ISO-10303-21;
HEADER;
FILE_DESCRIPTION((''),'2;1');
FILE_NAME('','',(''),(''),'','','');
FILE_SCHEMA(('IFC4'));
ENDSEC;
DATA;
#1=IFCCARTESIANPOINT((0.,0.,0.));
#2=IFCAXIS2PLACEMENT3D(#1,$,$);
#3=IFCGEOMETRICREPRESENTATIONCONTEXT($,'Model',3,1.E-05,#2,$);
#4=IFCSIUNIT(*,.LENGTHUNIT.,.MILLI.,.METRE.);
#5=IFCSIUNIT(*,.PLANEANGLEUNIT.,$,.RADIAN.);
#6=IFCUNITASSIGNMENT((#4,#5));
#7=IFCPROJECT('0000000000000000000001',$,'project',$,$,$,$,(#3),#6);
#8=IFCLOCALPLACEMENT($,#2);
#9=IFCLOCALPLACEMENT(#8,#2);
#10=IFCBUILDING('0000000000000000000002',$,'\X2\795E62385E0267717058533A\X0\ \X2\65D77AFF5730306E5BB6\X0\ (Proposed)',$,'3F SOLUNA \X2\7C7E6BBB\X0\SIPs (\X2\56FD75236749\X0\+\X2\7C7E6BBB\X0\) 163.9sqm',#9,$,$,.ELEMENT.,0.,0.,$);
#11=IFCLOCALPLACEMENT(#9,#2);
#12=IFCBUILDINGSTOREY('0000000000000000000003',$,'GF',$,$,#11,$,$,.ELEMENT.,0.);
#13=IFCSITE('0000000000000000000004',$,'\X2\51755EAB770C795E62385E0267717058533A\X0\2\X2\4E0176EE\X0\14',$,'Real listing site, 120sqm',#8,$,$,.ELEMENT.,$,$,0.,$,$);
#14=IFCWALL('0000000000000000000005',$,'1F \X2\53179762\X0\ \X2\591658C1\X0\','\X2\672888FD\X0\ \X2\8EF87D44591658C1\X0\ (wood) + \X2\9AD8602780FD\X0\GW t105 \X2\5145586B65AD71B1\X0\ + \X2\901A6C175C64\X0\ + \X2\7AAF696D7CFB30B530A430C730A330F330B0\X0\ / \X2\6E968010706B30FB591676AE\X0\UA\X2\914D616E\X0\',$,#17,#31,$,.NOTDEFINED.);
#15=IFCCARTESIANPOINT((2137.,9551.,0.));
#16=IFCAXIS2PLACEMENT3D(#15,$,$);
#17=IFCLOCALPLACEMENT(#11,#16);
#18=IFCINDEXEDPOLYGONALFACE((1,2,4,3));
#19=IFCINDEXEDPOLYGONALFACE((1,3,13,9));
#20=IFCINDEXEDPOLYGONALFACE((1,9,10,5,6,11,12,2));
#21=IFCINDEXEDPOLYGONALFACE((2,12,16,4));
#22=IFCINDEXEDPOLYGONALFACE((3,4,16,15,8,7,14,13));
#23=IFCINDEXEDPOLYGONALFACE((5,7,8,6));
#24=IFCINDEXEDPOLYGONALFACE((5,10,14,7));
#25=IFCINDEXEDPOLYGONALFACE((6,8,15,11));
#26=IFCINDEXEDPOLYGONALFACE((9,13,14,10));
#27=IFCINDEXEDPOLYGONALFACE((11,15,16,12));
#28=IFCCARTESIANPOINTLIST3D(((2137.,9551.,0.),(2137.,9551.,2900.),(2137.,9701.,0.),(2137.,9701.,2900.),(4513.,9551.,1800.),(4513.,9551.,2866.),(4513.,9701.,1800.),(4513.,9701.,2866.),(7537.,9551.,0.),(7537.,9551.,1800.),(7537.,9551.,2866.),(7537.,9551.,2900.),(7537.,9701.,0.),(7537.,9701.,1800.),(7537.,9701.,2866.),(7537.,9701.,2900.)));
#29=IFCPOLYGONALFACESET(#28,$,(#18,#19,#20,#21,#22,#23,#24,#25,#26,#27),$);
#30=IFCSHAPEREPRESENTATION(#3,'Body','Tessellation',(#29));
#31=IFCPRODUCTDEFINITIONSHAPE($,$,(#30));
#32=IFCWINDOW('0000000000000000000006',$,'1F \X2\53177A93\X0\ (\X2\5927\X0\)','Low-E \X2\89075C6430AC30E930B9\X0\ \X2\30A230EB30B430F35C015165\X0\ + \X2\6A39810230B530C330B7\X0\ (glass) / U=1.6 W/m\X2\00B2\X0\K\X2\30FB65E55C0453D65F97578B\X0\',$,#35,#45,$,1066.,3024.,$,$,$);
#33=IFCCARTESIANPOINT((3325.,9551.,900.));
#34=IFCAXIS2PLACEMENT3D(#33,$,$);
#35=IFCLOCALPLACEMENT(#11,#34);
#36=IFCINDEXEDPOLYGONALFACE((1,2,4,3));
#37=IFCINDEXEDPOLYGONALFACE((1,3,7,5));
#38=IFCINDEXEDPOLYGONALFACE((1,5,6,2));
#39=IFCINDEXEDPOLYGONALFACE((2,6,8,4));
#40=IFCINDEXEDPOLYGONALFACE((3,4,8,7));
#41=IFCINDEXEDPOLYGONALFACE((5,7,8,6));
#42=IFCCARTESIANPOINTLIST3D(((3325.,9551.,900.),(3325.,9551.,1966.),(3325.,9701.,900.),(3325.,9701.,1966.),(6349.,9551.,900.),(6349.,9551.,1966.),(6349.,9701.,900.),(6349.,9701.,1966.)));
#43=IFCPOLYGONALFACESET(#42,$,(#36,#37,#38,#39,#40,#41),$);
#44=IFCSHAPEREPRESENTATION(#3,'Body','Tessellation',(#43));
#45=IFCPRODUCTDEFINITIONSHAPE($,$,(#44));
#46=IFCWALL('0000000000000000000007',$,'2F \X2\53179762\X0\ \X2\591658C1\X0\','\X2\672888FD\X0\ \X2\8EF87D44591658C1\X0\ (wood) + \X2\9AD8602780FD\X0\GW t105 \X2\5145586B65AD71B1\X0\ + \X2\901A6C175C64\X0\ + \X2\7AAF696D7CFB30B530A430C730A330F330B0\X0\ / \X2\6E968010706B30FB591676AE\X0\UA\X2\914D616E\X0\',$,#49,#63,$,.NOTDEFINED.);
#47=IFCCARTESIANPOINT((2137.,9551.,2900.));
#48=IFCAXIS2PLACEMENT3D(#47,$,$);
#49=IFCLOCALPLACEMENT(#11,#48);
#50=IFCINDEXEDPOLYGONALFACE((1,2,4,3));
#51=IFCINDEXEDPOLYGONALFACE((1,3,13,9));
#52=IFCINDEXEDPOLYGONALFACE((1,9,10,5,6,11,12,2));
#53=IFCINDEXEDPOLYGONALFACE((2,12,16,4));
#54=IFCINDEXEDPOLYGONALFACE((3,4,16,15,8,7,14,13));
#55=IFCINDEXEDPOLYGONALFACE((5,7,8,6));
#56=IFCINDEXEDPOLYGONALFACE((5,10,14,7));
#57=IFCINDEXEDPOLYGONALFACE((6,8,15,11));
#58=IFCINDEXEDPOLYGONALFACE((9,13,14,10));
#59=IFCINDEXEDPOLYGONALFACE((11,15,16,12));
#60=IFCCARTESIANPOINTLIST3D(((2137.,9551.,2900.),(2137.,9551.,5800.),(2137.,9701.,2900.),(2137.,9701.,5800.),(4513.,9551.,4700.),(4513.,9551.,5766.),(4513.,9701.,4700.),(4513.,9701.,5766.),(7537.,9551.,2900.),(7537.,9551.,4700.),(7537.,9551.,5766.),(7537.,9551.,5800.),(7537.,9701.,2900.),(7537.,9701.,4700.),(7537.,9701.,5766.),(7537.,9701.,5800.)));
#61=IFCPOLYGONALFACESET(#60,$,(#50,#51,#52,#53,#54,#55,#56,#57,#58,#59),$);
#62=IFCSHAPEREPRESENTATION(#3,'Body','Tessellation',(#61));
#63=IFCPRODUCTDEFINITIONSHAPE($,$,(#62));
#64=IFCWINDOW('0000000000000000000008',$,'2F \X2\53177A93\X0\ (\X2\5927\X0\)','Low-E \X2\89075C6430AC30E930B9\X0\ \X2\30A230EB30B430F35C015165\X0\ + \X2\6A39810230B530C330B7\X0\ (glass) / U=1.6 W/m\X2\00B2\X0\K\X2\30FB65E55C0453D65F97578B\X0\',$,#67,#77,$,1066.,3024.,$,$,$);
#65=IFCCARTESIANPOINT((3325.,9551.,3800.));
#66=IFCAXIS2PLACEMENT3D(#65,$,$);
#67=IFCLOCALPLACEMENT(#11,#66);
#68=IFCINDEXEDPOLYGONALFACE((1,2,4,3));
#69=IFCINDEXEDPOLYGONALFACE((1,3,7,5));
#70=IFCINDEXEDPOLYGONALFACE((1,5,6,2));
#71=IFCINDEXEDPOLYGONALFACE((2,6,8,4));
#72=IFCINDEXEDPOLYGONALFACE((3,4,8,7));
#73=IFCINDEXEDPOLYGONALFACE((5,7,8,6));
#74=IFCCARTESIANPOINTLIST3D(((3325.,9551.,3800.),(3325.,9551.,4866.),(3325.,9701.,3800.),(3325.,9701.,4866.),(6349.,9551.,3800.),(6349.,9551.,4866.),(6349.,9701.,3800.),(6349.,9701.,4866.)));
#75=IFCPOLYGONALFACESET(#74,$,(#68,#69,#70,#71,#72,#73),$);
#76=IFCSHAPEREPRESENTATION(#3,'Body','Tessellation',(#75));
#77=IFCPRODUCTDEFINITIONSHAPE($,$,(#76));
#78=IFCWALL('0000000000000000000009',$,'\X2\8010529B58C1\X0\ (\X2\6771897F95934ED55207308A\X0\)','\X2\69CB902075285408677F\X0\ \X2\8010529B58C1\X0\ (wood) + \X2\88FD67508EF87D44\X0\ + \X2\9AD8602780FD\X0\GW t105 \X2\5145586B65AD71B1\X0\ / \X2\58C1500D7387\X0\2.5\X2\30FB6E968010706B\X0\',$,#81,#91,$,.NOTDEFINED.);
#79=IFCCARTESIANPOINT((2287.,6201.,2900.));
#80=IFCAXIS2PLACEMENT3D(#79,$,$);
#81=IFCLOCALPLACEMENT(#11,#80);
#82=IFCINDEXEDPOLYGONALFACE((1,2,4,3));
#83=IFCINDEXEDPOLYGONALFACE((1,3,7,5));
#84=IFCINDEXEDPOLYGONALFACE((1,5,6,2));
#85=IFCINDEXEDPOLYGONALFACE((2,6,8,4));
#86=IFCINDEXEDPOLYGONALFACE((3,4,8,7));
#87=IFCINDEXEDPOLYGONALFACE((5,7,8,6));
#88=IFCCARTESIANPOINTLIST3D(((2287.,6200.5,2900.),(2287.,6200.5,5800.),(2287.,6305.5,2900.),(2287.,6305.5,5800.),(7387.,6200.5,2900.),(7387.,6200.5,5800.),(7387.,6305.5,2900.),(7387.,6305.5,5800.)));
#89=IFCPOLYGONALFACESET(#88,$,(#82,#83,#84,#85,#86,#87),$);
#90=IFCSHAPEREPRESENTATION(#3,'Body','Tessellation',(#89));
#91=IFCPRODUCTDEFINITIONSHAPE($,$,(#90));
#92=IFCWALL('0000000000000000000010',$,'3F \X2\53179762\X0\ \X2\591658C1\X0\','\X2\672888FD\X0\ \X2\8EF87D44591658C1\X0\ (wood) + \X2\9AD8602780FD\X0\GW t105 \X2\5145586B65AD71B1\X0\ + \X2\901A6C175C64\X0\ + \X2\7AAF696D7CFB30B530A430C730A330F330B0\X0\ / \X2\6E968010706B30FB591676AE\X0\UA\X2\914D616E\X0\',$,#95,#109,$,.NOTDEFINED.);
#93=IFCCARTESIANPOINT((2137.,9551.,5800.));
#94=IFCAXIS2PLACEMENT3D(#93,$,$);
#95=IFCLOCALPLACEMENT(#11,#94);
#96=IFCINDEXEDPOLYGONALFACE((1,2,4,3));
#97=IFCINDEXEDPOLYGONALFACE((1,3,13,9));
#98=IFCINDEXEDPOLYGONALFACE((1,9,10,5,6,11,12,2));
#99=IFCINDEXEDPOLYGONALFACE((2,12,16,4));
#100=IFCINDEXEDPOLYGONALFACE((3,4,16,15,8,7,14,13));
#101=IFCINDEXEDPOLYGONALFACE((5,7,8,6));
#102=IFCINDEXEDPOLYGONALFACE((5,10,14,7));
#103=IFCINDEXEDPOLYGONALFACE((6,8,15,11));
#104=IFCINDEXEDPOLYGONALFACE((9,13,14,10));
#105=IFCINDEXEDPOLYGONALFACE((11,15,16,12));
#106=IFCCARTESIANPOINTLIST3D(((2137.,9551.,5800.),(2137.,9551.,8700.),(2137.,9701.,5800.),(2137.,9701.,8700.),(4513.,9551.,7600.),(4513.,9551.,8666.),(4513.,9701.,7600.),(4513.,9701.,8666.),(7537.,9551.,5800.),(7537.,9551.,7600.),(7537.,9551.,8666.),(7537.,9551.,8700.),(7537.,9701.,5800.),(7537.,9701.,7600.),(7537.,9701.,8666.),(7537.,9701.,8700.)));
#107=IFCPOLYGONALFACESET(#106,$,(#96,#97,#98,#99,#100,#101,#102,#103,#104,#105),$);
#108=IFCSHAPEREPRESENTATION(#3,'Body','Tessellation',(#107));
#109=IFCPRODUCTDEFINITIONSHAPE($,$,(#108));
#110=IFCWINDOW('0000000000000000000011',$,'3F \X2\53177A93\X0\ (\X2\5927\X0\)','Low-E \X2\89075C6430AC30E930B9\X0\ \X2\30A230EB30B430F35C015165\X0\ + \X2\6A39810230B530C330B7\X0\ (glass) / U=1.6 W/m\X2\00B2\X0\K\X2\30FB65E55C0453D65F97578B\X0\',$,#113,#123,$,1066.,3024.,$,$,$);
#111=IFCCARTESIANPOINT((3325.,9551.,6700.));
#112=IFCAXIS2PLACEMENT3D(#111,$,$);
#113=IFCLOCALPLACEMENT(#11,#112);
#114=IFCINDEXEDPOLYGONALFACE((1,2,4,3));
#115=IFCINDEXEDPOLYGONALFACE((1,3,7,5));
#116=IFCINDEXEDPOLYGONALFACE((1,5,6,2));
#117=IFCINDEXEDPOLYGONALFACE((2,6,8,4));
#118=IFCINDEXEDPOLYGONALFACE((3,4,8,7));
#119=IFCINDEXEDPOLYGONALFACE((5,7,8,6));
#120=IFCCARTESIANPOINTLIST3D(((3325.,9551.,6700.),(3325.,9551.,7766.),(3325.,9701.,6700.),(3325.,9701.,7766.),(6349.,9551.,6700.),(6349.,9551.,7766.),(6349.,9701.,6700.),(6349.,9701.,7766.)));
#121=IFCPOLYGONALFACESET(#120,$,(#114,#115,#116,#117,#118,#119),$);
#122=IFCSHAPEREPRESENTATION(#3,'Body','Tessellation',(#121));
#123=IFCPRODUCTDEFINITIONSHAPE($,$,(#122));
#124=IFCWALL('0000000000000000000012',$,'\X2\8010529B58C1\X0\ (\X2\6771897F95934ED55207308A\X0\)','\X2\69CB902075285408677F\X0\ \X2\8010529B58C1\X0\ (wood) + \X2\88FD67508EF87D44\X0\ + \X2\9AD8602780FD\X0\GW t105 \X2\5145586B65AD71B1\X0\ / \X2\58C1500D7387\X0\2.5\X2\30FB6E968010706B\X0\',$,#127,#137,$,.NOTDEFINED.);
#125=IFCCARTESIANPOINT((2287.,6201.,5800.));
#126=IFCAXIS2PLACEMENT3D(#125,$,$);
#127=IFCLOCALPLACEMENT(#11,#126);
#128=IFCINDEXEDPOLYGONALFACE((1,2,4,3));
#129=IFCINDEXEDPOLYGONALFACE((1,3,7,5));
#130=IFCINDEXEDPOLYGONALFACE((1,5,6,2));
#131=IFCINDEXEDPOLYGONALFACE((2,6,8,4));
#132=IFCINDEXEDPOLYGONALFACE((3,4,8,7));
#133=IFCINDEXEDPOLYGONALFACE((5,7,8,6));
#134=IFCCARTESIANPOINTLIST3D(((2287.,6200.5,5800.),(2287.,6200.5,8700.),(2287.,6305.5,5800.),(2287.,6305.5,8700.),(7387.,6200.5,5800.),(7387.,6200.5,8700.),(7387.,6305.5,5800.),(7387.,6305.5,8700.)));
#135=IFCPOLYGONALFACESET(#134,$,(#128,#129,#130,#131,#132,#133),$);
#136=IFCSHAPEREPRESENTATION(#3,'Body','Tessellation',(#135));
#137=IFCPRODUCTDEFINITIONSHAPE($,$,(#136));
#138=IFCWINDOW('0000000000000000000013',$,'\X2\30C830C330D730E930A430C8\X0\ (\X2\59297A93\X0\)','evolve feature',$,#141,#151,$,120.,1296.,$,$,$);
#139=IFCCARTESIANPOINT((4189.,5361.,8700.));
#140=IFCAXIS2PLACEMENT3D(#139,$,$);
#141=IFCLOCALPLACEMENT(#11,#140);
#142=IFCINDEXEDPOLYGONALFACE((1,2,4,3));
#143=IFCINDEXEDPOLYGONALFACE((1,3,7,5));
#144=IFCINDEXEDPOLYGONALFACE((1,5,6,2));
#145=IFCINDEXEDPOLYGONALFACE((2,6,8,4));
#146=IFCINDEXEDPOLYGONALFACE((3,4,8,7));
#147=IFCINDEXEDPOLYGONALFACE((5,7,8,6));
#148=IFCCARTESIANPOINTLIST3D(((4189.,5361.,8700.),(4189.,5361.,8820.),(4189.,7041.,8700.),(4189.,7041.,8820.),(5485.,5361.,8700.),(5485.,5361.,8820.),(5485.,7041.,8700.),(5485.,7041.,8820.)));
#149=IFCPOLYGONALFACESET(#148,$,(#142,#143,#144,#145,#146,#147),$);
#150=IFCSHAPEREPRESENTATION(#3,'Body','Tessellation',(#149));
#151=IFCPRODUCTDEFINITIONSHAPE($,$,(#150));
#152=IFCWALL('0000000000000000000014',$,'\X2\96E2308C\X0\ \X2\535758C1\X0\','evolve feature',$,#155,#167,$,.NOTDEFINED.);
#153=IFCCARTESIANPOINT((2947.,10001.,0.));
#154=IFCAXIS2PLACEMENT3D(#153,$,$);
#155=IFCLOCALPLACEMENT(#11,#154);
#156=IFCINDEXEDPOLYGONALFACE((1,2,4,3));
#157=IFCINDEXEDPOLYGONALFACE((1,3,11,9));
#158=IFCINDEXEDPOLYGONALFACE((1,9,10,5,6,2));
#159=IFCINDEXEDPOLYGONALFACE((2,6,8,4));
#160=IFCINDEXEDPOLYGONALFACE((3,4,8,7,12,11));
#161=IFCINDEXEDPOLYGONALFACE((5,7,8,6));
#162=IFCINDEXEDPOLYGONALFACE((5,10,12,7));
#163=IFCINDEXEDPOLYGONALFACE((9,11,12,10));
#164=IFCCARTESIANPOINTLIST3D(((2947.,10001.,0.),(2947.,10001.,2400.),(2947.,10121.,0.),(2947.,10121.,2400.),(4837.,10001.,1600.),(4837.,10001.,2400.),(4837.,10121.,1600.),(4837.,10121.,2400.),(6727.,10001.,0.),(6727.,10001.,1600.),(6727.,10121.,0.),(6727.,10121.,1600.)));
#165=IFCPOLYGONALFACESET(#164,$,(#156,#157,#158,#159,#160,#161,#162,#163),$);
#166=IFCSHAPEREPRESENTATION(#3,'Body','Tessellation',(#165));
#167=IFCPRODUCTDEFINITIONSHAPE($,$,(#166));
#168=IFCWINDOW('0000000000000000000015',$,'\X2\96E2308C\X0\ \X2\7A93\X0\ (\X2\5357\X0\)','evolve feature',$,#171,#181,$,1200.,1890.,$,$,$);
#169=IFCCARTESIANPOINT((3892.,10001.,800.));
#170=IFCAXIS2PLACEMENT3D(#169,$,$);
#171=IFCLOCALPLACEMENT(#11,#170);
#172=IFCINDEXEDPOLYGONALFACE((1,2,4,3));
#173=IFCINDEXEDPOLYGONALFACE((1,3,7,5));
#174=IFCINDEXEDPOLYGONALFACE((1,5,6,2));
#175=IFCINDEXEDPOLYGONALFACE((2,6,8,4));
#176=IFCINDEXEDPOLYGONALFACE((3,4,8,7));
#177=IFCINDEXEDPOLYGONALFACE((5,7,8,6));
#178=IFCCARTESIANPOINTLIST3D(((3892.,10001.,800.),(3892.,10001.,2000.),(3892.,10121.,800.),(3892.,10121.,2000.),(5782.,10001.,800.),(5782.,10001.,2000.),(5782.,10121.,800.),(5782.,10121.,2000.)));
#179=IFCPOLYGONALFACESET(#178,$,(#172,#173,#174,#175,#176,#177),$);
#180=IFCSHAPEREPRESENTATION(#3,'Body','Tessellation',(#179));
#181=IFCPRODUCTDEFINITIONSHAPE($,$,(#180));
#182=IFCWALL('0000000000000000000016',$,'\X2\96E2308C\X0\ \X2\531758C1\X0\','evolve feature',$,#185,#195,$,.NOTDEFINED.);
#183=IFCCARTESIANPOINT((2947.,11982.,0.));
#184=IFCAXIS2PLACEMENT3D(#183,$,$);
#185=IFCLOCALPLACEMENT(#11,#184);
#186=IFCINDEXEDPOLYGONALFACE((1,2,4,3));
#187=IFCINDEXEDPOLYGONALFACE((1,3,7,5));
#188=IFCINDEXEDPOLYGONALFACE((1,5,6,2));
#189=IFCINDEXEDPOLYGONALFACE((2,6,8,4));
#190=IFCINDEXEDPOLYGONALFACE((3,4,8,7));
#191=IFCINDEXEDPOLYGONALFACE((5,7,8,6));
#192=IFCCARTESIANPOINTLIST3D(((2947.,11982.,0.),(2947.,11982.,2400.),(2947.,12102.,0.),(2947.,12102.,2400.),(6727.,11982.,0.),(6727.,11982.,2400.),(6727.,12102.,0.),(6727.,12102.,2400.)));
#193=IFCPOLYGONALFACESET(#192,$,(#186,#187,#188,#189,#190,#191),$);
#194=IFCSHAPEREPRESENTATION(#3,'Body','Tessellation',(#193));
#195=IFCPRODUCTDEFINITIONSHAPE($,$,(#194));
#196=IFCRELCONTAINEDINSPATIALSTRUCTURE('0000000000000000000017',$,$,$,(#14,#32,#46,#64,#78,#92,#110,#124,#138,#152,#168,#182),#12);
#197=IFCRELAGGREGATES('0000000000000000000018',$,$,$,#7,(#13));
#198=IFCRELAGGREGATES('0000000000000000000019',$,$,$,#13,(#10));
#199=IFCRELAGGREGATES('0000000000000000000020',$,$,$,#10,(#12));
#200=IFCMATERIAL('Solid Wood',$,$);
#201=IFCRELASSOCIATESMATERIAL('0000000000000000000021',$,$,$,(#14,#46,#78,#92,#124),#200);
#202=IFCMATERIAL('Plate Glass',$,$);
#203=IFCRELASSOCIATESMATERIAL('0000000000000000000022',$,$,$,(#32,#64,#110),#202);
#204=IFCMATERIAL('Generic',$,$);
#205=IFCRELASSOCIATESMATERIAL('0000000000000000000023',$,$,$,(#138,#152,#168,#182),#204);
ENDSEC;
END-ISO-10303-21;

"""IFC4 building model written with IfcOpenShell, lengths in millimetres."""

from ifc_helpers import new_model, si_unit, frame, frame_2d, origin, place, context, project, spatial, rectangle, extrude, material, element, fill, save


model = new_model("IFC4")

# Units and contexts
model_context = context("Model", 3, precision=1e-05, world=origin())
ifc_project = project(units=[si_unit("LENGTHUNIT", "METRE", prefix="MILLI"), si_unit("PLANEANGLEUNIT", "RADIAN")], contexts=[model_context])

# Site, building, storey
site_placement = place(None, origin())
site = spatial("IfcSite", under=ifc_project, at=site_placement, Name="兵庫県神戸市東灘区2丁目14", ObjectType="Real listing site, 120sqm", CompositionType="ELEMENT", RefElevation=0.0)
building_placement = place(site_placement, origin())
building = spatial("IfcBuilding", under=site, at=building_placement, Name="神戸市東灘区 旗竿地の家 (Proposed)", ObjectType="3F SOLUNA 籾殻SIPs (国産杉+籾殻) 163.9sqm", CompositionType="ELEMENT", ElevationOfRefHeight=0.0, ElevationOfTerrain=0.0)
storey_placement = place(building_placement, origin())
storey = spatial("IfcBuildingStorey", under=building, at=storey_placement, Name="GF", CompositionType="ELEMENT", Elevation=0.0)

# Shared definitions
ifc_material_1 = material(Name="Generic")

# Wall, opening, window
ifc_material_2 = material(Name="Solid Wood")
wall_1_placement = place(storey_placement, frame((2137.0, 9551.0, 0.0)))
wall_1 = element("IfcWall", 1, at=wall_1_placement, inside=storey, material=ifc_material_2, Name="1F 北面 外壁", Description="木製 軸組外壁 (wood) + 高性能GW t105 充填断熱 + 通気層 + 窯業系サイディング / 準耐火・外皮UA配慮", PredefinedType="NOTDEFINED", context=model_context, shape_type="SweptSolid", body=[
    extrude(rectangle(XDim=5400.0, YDim=150.0, at=frame_2d((2700.0, 75.0))), frame((2137.0, 9551.0, 0.0)), (0.0, 0.0, 1.0), 2900.0),
])
opening_1_placement = place(storey_placement, frame((3325.0, 9551.0, 900.0)))
opening_1 = element("IfcOpeningElement", 2, at=opening_1_placement, cuts=wall_1, PredefinedType="NOTDEFINED", context=model_context, shape_type="SweptSolid", body=[
    extrude(rectangle(XDim=3024.0, YDim=150.0, at=frame_2d((1512.0, 75.0))), frame((3325.0, 9551.0, 900.0)), (0.0, 0.0, 1.0), 1066.0),
])
ifc_material_3 = material(Name="Plate Glass")
window_1_placement = place(storey_placement, frame((3325.0, 9551.0, 900.0)))
window_1 = element("IfcWindow", 3, at=window_1_placement, inside=storey, material=ifc_material_3, Name="1F 北窓 (大)", Description="Low-E 複層ガラス アルゴン封入 + 樹脂サッシ (glass) / U=1.6 W/m²K・日射取得型", OverallHeight=1066.0, OverallWidth=3024.0, context=model_context, shape_type="SweptSolid", body=[
    extrude(rectangle(XDim=3024.0, YDim=150.0, at=frame_2d((1512.0, 75.0))), frame((3325.0, 9551.0, 900.0)), (0.0, 0.0, 1.0), 1066.0),
])
fill(opening_1, window_1)

# Wall, opening, window
wall_2_placement = place(storey_placement, frame((2137.0, 9551.0, 2900.0)))
wall_2 = element("IfcWall", 4, at=wall_2_placement, inside=storey, material=ifc_material_2, Name="2F 北面 外壁", Description="木製 軸組外壁 (wood) + 高性能GW t105 充填断熱 + 通気層 + 窯業系サイディング / 準耐火・外皮UA配慮", PredefinedType="NOTDEFINED", context=model_context, shape_type="SweptSolid", body=[
    extrude(rectangle(XDim=5400.0, YDim=150.0, at=frame_2d((2700.0, 75.0))), frame((2137.0, 9551.0, 2900.0)), (0.0, 0.0, 1.0), 2900.0),
])
opening_2_placement = place(storey_placement, frame((3325.0, 9551.0, 3800.0)))
opening_2 = element("IfcOpeningElement", 5, at=opening_2_placement, cuts=wall_2, PredefinedType="NOTDEFINED", context=model_context, shape_type="SweptSolid", body=[
    extrude(rectangle(XDim=3024.0, YDim=150.0, at=frame_2d((1512.0, 75.0))), frame((3325.0, 9551.0, 3800.0)), (0.0, 0.0, 1.0), 1066.0),
])
window_2_placement = place(storey_placement, frame((3325.0, 9551.0, 3800.0)))
window_2 = element("IfcWindow", 6, at=window_2_placement, inside=storey, material=ifc_material_3, Name="2F 北窓 (大)", Description="Low-E 複層ガラス アルゴン封入 + 樹脂サッシ (glass) / U=1.6 W/m²K・日射取得型", OverallHeight=1066.0, OverallWidth=3024.0, context=model_context, shape_type="SweptSolid", body=[
    extrude(rectangle(XDim=3024.0, YDim=150.0, at=frame_2d((1512.0, 75.0))), frame((3325.0, 9551.0, 3800.0)), (0.0, 0.0, 1.0), 1066.0),
])
fill(opening_2, window_2)

# Wall
wall_3_placement = place(storey_placement, frame((2287.0, 6201.0, 2900.0)))
element("IfcWall", 7, at=wall_3_placement, inside=storey, material=ifc_material_2, Name="耐力壁 (東西間仕切り)", Description="構造用合板 耐力壁 (wood) + 製材軸組 + 高性能GW t105 充填断熱 / 壁倍率2.5・準耐火", PredefinedType="NOTDEFINED", context=model_context, shape_type="SweptSolid", body=[
    extrude(rectangle(XDim=5100.0, YDim=105.0, at=frame_2d((2550.0, 52.0))), frame((2287.0, 6201.0, 2900.0)), (0.0, 0.0, 1.0), 2900.0),
])

# Wall, opening, window
wall_4_placement = place(storey_placement, frame((2137.0, 9551.0, 5800.0)))
wall_4 = element("IfcWall", 8, at=wall_4_placement, inside=storey, material=ifc_material_2, Name="3F 北面 外壁", Description="木製 軸組外壁 (wood) + 高性能GW t105 充填断熱 + 通気層 + 窯業系サイディング / 準耐火・外皮UA配慮", PredefinedType="NOTDEFINED", context=model_context, shape_type="SweptSolid", body=[
    extrude(rectangle(XDim=5400.0, YDim=150.0, at=frame_2d((2700.0, 75.0))), frame((2137.0, 9551.0, 5800.0)), (0.0, 0.0, 1.0), 2900.0),
])
opening_3_placement = place(storey_placement, frame((3325.0, 9551.0, 6700.0)))
opening_3 = element("IfcOpeningElement", 9, at=opening_3_placement, cuts=wall_4, PredefinedType="NOTDEFINED", context=model_context, shape_type="SweptSolid", body=[
    extrude(rectangle(XDim=3024.0, YDim=150.0, at=frame_2d((1512.0, 75.0))), frame((3325.0, 9551.0, 6700.0)), (0.0, 0.0, 1.0), 1066.0),
])
window_3_placement = place(storey_placement, frame((3325.0, 9551.0, 6700.0)))
window_3 = element("IfcWindow", 10, at=window_3_placement, inside=storey, material=ifc_material_3, Name="3F 北窓 (大)", Description="Low-E 複層ガラス アルゴン封入 + 樹脂サッシ (glass) / U=1.6 W/m²K・日射取得型", OverallHeight=1066.0, OverallWidth=3024.0, context=model_context, shape_type="SweptSolid", body=[
    extrude(rectangle(XDim=3024.0, YDim=150.0, at=frame_2d((1512.0, 75.0))), frame((3325.0, 9551.0, 6700.0)), (0.0, 0.0, 1.0), 1066.0),
])
fill(opening_3, window_3)

# Wall
wall_5_placement = place(storey_placement, frame((2287.0, 6201.0, 5800.0)))
element("IfcWall", 11, at=wall_5_placement, inside=storey, material=ifc_material_2, Name="耐力壁 (東西間仕切り)", Description="構造用合板 耐力壁 (wood) + 製材軸組 + 高性能GW t105 充填断熱 / 壁倍率2.5・準耐火", PredefinedType="NOTDEFINED", context=model_context, shape_type="SweptSolid", body=[
    extrude(rectangle(XDim=5100.0, YDim=105.0, at=frame_2d((2550.0, 52.0))), frame((2287.0, 6201.0, 5800.0)), (0.0, 0.0, 1.0), 2900.0),
])

# Window
window_4_placement = place(storey_placement, frame((4189.0, 5361.0, 8700.0)))
element("IfcWindow", 12, at=window_4_placement, inside=storey, material=ifc_material_1, Name="トップライト (天窓)", Description="evolve feature", OverallHeight=120.0, OverallWidth=1296.0, context=model_context, shape_type="SweptSolid", body=[
    extrude(rectangle(XDim=1296.0, YDim=1680.0, at=frame_2d((648.0, 840.0))), frame((4189.0, 5361.0, 8700.0)), (0.0, 0.0, 1.0), 120.0),
])

# Wall, opening, window
wall_6_placement = place(storey_placement, frame((2947.0, 10001.0, 0.0)))
wall_6 = element("IfcWall", 13, at=wall_6_placement, inside=storey, material=ifc_material_1, Name="離れ 南壁", Description="evolve feature", PredefinedType="NOTDEFINED", context=model_context, shape_type="SweptSolid", body=[
    extrude(rectangle(XDim=3780.0, YDim=120.0, at=frame_2d((1890.0, 60.0))), frame((2947.0, 10001.0, 0.0)), (0.0, 0.0, 1.0), 2400.0),
])
opening_4_placement = place(storey_placement, frame((3892.0, 10001.0, 800.0)))
opening_4 = element("IfcOpeningElement", 14, at=opening_4_placement, cuts=wall_6, PredefinedType="NOTDEFINED", context=model_context, shape_type="SweptSolid", body=[
    extrude(rectangle(XDim=1890.0, YDim=120.0, at=frame_2d((945.0, 60.0))), frame((3892.0, 10001.0, 800.0)), (0.0, 0.0, 1.0), 1200.0),
])
window_5_placement = place(storey_placement, frame((3892.0, 10001.0, 800.0)))
window_5 = element("IfcWindow", 15, at=window_5_placement, inside=storey, material=ifc_material_1, Name="離れ 窓 (南)", Description="evolve feature", OverallHeight=1200.0, OverallWidth=1890.0, context=model_context, shape_type="SweptSolid", body=[
    extrude(rectangle(XDim=1890.0, YDim=120.0, at=frame_2d((945.0, 60.0))), frame((3892.0, 10001.0, 800.0)), (0.0, 0.0, 1.0), 1200.0),
])
fill(opening_4, window_5)

# Wall
wall_7_placement = place(storey_placement, frame((2947.0, 11982.0, 0.0)))
element("IfcWall", 16, at=wall_7_placement, inside=storey, material=ifc_material_1, Name="離れ 北壁", Description="evolve feature", PredefinedType="NOTDEFINED", context=model_context, shape_type="SweptSolid", body=[
    extrude(rectangle(XDim=3780.0, YDim=120.0, at=frame_2d((1890.0, 60.0))), frame((2947.0, 11982.0, 0.0)), (0.0, 0.0, 1.0), 2400.0),
])

save(model, "model.ifc")
